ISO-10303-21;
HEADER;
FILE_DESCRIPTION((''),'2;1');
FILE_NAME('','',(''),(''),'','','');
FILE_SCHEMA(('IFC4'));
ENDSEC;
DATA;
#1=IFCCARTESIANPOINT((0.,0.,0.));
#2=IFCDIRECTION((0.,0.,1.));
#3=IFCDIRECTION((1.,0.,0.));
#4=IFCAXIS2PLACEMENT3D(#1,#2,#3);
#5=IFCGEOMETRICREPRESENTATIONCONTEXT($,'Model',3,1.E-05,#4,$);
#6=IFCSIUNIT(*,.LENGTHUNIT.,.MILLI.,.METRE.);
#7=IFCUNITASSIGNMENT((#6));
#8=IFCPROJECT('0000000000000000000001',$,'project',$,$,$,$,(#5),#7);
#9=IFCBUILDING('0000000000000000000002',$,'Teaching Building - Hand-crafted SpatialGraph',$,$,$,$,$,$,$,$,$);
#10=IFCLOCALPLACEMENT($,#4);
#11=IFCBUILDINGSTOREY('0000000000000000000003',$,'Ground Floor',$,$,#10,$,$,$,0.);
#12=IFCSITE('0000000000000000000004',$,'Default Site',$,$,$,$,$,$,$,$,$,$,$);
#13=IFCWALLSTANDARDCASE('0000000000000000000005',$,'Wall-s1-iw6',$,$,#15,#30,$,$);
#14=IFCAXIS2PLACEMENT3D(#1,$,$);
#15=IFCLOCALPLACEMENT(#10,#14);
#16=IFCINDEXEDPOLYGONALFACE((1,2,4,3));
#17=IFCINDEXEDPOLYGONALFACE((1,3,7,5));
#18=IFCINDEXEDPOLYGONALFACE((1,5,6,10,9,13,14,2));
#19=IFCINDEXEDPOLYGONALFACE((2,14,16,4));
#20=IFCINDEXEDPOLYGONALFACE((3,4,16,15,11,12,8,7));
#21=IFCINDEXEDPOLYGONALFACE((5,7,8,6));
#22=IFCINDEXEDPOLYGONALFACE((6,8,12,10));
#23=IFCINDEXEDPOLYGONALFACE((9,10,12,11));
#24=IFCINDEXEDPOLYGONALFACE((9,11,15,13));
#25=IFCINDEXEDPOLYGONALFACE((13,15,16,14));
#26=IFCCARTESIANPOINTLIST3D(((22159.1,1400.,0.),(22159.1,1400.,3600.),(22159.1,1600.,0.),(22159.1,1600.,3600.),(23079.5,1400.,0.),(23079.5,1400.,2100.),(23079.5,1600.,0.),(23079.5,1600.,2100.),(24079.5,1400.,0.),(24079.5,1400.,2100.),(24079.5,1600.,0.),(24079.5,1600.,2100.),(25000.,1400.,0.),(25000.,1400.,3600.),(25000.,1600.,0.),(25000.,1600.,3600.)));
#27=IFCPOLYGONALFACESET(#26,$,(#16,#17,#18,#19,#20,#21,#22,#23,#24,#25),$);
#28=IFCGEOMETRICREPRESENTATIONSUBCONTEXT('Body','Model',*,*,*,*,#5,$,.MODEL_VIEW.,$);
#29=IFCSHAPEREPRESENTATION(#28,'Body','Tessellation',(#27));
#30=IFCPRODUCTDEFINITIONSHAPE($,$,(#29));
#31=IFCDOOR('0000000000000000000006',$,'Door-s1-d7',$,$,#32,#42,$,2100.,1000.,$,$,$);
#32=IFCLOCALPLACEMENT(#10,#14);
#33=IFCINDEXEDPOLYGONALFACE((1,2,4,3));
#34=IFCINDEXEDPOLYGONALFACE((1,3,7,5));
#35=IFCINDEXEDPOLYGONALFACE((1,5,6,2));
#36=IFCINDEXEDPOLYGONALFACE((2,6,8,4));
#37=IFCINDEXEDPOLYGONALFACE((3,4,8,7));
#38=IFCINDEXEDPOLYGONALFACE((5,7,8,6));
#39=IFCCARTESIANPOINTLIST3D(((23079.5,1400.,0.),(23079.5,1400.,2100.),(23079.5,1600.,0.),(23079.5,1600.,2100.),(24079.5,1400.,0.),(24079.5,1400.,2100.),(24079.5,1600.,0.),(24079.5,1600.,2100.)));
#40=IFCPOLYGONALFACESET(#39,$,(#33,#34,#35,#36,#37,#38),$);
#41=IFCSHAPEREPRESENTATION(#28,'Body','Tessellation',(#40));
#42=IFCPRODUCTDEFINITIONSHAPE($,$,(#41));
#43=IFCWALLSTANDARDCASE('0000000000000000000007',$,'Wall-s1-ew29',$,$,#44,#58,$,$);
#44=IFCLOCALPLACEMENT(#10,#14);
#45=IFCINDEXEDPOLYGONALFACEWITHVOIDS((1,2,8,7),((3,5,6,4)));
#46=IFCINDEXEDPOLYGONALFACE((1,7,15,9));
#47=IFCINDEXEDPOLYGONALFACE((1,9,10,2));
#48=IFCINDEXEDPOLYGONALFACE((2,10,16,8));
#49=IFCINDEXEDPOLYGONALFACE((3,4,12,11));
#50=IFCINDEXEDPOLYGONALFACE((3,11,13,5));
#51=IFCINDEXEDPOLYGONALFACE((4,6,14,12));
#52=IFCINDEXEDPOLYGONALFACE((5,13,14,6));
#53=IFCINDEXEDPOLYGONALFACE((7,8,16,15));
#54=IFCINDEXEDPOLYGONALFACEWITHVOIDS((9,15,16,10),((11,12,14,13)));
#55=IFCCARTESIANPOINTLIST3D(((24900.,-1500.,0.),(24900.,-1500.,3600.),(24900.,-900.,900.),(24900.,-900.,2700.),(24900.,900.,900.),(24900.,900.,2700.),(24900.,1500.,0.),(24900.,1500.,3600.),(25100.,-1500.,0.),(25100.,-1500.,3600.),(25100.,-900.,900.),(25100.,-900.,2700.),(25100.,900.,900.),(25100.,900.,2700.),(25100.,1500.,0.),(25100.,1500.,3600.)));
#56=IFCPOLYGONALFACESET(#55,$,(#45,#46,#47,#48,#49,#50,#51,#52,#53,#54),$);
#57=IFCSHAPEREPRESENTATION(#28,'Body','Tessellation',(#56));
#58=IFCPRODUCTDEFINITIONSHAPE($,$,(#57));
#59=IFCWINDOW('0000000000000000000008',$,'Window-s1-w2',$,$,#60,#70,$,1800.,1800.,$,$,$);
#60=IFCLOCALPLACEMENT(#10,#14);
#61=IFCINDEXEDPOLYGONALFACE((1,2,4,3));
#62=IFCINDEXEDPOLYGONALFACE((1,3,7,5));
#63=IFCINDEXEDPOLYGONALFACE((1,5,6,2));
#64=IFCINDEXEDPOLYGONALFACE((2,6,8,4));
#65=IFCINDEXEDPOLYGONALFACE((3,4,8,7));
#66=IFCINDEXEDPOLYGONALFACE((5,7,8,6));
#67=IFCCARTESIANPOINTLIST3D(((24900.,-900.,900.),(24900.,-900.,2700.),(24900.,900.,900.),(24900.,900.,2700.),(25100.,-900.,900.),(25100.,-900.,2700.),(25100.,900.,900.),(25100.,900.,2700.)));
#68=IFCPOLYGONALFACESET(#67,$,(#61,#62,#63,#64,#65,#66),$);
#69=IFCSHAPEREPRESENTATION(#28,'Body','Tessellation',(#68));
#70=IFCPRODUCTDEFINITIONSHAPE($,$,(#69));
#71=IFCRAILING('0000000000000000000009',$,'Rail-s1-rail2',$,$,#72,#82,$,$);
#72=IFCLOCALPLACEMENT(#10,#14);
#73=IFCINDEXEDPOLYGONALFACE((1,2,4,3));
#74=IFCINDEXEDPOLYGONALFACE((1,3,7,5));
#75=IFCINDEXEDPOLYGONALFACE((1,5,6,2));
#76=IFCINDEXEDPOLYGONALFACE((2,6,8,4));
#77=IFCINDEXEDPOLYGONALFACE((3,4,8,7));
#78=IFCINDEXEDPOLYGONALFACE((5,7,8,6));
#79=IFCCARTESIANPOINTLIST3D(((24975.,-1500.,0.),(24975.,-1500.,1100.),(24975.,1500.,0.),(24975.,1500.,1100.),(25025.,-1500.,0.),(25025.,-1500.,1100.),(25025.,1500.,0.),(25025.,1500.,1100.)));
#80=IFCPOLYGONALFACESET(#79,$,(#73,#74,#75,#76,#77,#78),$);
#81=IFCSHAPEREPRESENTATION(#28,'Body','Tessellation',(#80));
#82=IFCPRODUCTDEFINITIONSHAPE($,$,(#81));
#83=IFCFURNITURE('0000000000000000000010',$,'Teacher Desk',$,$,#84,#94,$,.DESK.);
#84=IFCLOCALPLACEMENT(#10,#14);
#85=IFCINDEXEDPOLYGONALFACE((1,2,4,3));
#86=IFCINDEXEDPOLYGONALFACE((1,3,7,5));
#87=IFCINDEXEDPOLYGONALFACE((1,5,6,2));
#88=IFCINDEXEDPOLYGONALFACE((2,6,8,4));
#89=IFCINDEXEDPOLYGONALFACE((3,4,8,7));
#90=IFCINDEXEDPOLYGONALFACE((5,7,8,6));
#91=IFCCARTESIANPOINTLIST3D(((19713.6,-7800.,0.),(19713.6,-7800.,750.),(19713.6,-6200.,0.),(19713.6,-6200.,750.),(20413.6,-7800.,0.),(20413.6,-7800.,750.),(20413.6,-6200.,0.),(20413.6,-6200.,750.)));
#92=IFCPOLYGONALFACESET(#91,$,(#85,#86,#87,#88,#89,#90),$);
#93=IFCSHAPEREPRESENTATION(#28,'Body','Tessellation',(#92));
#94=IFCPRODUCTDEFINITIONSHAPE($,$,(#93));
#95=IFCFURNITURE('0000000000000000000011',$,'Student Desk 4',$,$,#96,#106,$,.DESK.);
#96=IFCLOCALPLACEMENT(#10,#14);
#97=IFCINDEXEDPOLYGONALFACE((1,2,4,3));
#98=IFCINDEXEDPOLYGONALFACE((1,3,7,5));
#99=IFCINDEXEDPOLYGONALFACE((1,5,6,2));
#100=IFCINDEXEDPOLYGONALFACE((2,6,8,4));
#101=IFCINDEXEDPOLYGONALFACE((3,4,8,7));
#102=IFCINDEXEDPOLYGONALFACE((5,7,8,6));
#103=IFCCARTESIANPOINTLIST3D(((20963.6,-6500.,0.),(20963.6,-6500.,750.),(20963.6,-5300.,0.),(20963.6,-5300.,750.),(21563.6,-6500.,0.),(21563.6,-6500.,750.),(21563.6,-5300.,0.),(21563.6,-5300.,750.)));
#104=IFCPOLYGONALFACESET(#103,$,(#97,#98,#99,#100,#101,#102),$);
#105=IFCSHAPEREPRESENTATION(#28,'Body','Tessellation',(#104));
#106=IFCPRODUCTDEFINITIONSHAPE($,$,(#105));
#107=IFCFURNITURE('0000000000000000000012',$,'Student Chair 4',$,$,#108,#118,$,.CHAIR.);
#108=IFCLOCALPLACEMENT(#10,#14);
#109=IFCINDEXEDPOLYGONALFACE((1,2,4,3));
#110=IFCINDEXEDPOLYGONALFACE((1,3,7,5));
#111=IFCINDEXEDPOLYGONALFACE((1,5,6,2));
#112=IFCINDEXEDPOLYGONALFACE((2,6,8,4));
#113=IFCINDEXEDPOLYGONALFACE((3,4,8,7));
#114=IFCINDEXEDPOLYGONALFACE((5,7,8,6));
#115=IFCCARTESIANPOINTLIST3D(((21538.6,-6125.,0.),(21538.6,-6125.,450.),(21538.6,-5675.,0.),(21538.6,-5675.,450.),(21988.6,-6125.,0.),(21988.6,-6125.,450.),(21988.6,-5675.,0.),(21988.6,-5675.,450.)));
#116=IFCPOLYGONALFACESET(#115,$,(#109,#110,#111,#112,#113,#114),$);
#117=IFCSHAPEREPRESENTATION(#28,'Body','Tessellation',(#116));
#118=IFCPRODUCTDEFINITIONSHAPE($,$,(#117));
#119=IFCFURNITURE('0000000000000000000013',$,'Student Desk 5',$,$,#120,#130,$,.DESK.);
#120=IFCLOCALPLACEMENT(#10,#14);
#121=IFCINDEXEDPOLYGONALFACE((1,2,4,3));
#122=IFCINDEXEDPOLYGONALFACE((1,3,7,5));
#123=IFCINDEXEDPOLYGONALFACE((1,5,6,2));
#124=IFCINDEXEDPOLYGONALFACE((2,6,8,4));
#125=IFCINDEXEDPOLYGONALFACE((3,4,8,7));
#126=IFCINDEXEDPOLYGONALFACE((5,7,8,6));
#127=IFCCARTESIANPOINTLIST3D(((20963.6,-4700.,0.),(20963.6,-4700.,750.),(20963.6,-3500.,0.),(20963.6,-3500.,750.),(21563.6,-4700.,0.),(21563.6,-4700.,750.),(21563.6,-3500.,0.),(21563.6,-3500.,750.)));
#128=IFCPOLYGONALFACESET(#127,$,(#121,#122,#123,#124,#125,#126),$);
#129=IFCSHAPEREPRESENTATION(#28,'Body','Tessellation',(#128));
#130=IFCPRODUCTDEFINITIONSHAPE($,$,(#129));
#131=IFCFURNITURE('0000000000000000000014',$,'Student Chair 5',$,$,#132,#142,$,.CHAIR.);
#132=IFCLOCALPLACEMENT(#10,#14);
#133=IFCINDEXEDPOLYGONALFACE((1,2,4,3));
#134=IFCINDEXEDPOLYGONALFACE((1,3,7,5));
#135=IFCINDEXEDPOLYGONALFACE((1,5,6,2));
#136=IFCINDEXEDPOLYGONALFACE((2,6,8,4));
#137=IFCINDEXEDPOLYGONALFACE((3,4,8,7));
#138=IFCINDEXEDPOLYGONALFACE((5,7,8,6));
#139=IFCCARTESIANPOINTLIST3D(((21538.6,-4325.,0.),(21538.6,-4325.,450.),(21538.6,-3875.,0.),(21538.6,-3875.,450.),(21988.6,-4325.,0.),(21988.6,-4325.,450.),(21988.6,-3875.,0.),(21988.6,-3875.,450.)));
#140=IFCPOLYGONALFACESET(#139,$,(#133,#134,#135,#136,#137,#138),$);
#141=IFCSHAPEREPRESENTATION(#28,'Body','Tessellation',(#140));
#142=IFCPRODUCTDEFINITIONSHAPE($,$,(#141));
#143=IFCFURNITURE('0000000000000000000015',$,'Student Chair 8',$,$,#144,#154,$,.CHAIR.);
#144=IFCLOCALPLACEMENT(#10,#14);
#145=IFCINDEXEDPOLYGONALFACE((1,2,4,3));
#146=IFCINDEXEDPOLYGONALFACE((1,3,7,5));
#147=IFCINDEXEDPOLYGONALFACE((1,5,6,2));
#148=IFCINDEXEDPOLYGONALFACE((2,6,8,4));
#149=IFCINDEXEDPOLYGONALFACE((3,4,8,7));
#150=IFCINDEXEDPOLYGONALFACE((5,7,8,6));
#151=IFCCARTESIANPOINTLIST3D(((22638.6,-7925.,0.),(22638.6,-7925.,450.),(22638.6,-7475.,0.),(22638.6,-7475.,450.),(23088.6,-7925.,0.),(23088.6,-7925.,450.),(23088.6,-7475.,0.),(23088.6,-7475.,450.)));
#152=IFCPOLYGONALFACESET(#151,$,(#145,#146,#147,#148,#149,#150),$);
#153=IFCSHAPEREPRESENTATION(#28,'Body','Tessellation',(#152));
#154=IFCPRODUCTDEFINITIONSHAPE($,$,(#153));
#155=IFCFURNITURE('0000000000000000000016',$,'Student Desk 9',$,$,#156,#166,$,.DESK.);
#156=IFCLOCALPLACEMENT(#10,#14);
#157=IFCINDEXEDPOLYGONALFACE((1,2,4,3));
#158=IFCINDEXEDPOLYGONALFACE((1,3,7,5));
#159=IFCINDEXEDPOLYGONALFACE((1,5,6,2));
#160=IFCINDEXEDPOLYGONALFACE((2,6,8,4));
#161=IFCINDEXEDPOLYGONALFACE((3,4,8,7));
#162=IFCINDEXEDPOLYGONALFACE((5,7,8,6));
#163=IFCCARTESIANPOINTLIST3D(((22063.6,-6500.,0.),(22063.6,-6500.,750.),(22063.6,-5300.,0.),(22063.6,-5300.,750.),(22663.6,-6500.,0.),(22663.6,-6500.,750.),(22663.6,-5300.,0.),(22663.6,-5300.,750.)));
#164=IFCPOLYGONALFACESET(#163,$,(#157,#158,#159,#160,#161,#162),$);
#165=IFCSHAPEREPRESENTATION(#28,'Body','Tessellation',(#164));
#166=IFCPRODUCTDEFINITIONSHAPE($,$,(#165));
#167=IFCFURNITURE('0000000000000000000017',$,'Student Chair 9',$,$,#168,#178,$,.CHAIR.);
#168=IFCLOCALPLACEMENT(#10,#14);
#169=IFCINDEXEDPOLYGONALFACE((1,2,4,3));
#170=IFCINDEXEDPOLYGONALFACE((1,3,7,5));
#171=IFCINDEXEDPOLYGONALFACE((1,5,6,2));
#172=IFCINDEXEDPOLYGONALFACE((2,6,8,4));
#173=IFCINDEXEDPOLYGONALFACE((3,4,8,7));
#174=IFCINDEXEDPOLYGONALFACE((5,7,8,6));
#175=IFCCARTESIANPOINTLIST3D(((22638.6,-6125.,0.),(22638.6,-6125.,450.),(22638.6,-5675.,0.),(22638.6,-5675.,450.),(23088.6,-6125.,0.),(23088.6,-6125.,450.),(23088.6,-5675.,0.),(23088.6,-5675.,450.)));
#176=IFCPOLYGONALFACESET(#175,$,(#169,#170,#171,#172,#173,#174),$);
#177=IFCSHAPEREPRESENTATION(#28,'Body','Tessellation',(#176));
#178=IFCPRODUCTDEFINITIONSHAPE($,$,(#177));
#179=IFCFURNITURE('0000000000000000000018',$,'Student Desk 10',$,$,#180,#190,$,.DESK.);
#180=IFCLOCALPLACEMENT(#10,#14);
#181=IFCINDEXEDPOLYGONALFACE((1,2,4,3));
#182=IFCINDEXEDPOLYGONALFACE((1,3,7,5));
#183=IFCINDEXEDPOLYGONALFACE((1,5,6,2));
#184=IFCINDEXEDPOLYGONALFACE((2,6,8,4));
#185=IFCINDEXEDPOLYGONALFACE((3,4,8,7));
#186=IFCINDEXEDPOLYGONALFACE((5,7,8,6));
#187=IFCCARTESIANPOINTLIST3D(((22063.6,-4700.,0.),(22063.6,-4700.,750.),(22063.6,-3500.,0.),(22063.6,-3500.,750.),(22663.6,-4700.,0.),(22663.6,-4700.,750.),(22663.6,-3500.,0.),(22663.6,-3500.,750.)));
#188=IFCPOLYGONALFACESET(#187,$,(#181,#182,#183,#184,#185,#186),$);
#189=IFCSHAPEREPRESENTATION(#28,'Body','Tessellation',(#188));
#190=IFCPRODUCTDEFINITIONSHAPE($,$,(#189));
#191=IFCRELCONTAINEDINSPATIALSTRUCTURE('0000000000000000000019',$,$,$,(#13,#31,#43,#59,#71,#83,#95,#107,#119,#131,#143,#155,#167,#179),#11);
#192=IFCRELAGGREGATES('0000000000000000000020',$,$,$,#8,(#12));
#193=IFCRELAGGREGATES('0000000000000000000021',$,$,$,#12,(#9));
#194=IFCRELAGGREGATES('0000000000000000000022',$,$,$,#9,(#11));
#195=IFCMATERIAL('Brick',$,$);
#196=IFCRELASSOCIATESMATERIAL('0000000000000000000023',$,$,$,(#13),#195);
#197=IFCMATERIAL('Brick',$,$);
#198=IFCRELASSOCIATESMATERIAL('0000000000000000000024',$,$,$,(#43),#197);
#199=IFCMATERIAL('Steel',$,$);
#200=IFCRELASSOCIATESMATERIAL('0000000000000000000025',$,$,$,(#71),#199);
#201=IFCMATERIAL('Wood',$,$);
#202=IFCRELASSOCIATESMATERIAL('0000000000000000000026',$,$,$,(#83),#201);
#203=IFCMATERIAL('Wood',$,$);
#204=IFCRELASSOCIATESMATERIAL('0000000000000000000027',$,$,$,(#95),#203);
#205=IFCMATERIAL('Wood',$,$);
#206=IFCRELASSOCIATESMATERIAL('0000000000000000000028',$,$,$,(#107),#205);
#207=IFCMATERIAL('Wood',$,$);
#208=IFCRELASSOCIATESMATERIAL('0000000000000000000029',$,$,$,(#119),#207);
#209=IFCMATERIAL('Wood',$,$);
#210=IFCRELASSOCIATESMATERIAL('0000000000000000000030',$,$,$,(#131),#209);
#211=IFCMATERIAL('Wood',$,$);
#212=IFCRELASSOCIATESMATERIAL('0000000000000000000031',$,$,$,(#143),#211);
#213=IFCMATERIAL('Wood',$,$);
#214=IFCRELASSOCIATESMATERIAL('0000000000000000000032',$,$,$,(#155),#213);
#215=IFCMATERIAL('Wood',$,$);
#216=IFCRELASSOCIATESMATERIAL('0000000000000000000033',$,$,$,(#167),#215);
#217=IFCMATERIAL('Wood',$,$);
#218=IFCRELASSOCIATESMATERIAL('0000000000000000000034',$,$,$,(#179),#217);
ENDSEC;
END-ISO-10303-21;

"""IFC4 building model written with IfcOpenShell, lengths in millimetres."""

from ifc_helpers import new_model, si_unit, frame, frame_2d, origin_with_axes, origin_2d, place, context, subcontext, project, spatial, rectangle, extrude, material, element, fill, save


model = new_model("IFC4")

# Units and contexts
model_context = context("Model", 3, precision=1e-05, world=origin_with_axes())
body_context = subcontext(model_context, "Body", "Model", "MODEL_VIEW")
ifc_project = project(units=[si_unit("LENGTHUNIT", "METRE", prefix="MILLI")], contexts=[model_context])

# Site, building, storey
site = spatial("IfcSite", under=ifc_project, Name="Default Site")
building = spatial("IfcBuilding", under=site, Name="Teaching Building - Hand-crafted SpatialGraph")
storey_placement = place(None, origin_with_axes())
storey = spatial("IfcBuildingStorey", under=building, at=storey_placement, Name="Ground Floor", Elevation=0.0)

# Wall, opening, door
ifc_material_1 = material(Name="Brick")
wall_1_placement = place(storey_placement, frame((22159.1, 1500.0, 0.0), z_axis=(0.0, 0.0, 1.0), x_axis=(1.0, 0.0, 0.0)))
wall_1 = element("IfcWallStandardCase", 1, at=wall_1_placement, inside=storey, material=ifc_material_1, Name="Wall-s1-iw6", context=body_context, shape_type="SweptSolid", body=[
    extrude(rectangle(XDim=2840.9, YDim=200.0, at=frame_2d((1420.5, 0.0))), origin_with_axes(), (0.0, 0.0, 1.0), 3600.0),
])
opening_1_placement = place(wall_1_placement, frame((920.5, 0.0, 0.0), z_axis=(0.0, 0.0, 1.0), x_axis=(1.0, 0.0, 0.0)))
opening_1 = element("IfcOpeningElement", 2, at=opening_1_placement, cuts=wall_1, context=body_context, shape_type="SweptSolid", body=[
    extrude(rectangle(XDim=1000.0, YDim=400.0, at=frame_2d((500.0, 0.0))), origin_with_axes(), (0.0, 0.0, 1.0), 2100.0),
])
door_placement = place(storey_placement, frame((23079.5, 1500.0, 0.0), z_axis=(0.0, 0.0, 1.0), x_axis=(1.0, 0.0, 0.0)))
door = element("IfcDoor", 3, at=door_placement, inside=storey, Name="Door-s1-d7", OverallHeight=2100.0, OverallWidth=1000.0, context=body_context, shape_type="SweptSolid", body=[
    extrude(rectangle(XDim=1000.0, YDim=200.0, at=frame_2d((500.0, 0.0))), origin_with_axes(), (0.0, 0.0, 1.0), 2100.0),
])
fill(opening_1, door)

# Wall, opening, window
ifc_material_2 = material(Name="Brick")
wall_2_placement = place(storey_placement, frame((25000.0, -1500.0, 0.0), z_axis=(0.0, 0.0, 1.0), x_axis=(0.0, 1.0, 0.0)))
wall_2 = element("IfcWallStandardCase", 4, at=wall_2_placement, inside=storey, material=ifc_material_2, Name="Wall-s1-ew29", context=body_context, shape_type="SweptSolid", body=[
    extrude(rectangle(XDim=3000.0, YDim=200.0, at=frame_2d((1500.0, 0.0))), origin_with_axes(), (0.0, 0.0, 1.0), 3600.0),
])
opening_2_placement = place(wall_2_placement, frame((600.0, 0.0, 900.0), z_axis=(0.0, 0.0, 1.0), x_axis=(1.0, 0.0, 0.0)))
opening_2 = element("IfcOpeningElement", 5, at=opening_2_placement, cuts=wall_2, context=body_context, shape_type="SweptSolid", body=[
    extrude(rectangle(XDim=1800.0, YDim=400.0, at=frame_2d((900.0, 0.0))), origin_with_axes(), (0.0, 0.0, 1.0), 1800.0),
])
window_placement = place(storey_placement, frame((25000.0, -900.0, 900.0), z_axis=(0.0, 0.0, 1.0), x_axis=(0.0, 1.0, 0.0)))
window = element("IfcWindow", 6, at=window_placement, inside=storey, Name="Window-s1-w2", OverallHeight=1800.0, OverallWidth=1800.0, context=body_context, shape_type="SweptSolid", body=[
    extrude(rectangle(XDim=1800.0, YDim=200.0, at=frame_2d((900.0, 0.0))), origin_with_axes(), (0.0, 0.0, 1.0), 1800.0),
])
fill(opening_2, window)

# Railing
ifc_material_3 = material(Name="Steel")
railing_placement = place(storey_placement, frame((25000.0, -1500.0, 0.0), z_axis=(0.0, 0.0, 1.0), x_axis=(0.0, 1.0, 0.0)))
element("IfcRailing", 7, at=railing_placement, inside=storey, material=ifc_material_3, Name="Rail-s1-rail2", context=body_context, shape_type="SweptSolid", body=[
    extrude(rectangle(XDim=3000.0, YDim=50.0, at=frame_2d((1500.0, 0.0))), origin_with_axes(), (0.0, 0.0, 1.0), 1100.0),
])

# Furniture
ifc_material_4 = material(Name="Wood")
furniture_1_placement = place(storey_placement, frame((20063.6, -7000.0, 0.0), z_axis=(0.0, 0.0, 1.0), x_axis=(0.0, 1.0, 0.0)))
element("IfcFurniture", 8, at=furniture_1_placement, inside=storey, material=ifc_material_4, Name="Teacher Desk", PredefinedType="DESK", context=body_context, shape_type="SweptSolid", body=[
    extrude(rectangle(XDim=1600.0, YDim=700.0, at=origin_2d()), origin_with_axes(), (0.0, 0.0, 1.0), 750.0),
])
ifc_material_5 = material(Name="Wood")
furniture_2_placement = place(storey_placement, frame((21263.6, -5900.0, 0.0), z_axis=(0.0, 0.0, 1.0), x_axis=(0.0, 1.0, 0.0)))
element("IfcFurniture", 9, at=furniture_2_placement, inside=storey, material=ifc_material_5, Name="Student Desk 4", PredefinedType="DESK", context=body_context, shape_type="SweptSolid", body=[
    extrude(rectangle(XDim=1200.0, YDim=600.0, at=origin_2d()), origin_with_axes(), (0.0, 0.0, 1.0), 750.0),
])
ifc_material_6 = material(Name="Wood")
furniture_3_placement = place(storey_placement, frame((21763.6, -5900.0, 0.0), z_axis=(0.0, 0.0, 1.0), x_axis=(1.0, 0.0, 0.0)))
element("IfcFurniture", 10, at=furniture_3_placement, inside=storey, material=ifc_material_6, Name="Student Chair 4", PredefinedType="CHAIR", context=body_context, shape_type="SweptSolid", body=[
    extrude(rectangle(XDim=450.0, YDim=450.0, at=origin_2d()), origin_with_axes(), (0.0, 0.0, 1.0), 450.0),
])
ifc_material_7 = material(Name="Wood")
furniture_4_placement = place(storey_placement, frame((21263.6, -4100.0, 0.0), z_axis=(0.0, 0.0, 1.0), x_axis=(0.0, 1.0, 0.0)))
element("IfcFurniture", 11, at=furniture_4_placement, inside=storey, material=ifc_material_7, Name="Student Desk 5", PredefinedType="DESK", context=body_context, shape_type="SweptSolid", body=[
    extrude(rectangle(XDim=1200.0, YDim=600.0, at=origin_2d()), origin_with_axes(), (0.0, 0.0, 1.0), 750.0),
])
ifc_material_8 = material(Name="Wood")
furniture_5_placement = place(storey_placement, frame((21763.6, -4100.0, 0.0), z_axis=(0.0, 0.0, 1.0), x_axis=(1.0, 0.0, 0.0)))
element("IfcFurniture", 12, at=furniture_5_placement, inside=storey, material=ifc_material_8, Name="Student Chair 5", PredefinedType="CHAIR", context=body_context, shape_type="SweptSolid", body=[
    extrude(rectangle(XDim=450.0, YDim=450.0, at=origin_2d()), origin_with_axes(), (0.0, 0.0, 1.0), 450.0),
])
ifc_material_9 = material(Name="Wood")
furniture_6_placement = place(storey_placement, frame((22863.6, -7700.0, 0.0), z_axis=(0.0, 0.0, 1.0), x_axis=(1.0, 0.0, 0.0)))
element("IfcFurniture", 13, at=furniture_6_placement, inside=storey, material=ifc_material_9, Name="Student Chair 8", PredefinedType="CHAIR", context=body_context, shape_type="SweptSolid", body=[
    extrude(rectangle(XDim=450.0, YDim=450.0, at=origin_2d()), origin_with_axes(), (0.0, 0.0, 1.0), 450.0),
])
ifc_material_10 = material(Name="Wood")
furniture_7_placement = place(storey_placement, frame((22363.6, -5900.0, 0.0), z_axis=(0.0, 0.0, 1.0), x_axis=(0.0, 1.0, 0.0)))
element("IfcFurniture", 14, at=furniture_7_placement, inside=storey, material=ifc_material_10, Name="Student Desk 9", PredefinedType="DESK", context=body_context, shape_type="SweptSolid", body=[
    extrude(rectangle(XDim=1200.0, YDim=600.0, at=origin_2d()), origin_with_axes(), (0.0, 0.0, 1.0), 750.0),
])
ifc_material_11 = material(Name="Wood")
furniture_8_placement = place(storey_placement, frame((22863.6, -5900.0, 0.0), z_axis=(0.0, 0.0, 1.0), x_axis=(1.0, 0.0, 0.0)))
element("IfcFurniture", 15, at=furniture_8_placement, inside=storey, material=ifc_material_11, Name="Student Chair 9", PredefinedType="CHAIR", context=body_context, shape_type="SweptSolid", body=[
    extrude(rectangle(XDim=450.0, YDim=450.0, at=origin_2d()), origin_with_axes(), (0.0, 0.0, 1.0), 450.0),
])
ifc_material_12 = material(Name="Wood")
furniture_9_placement = place(storey_placement, frame((22363.6, -4100.0, 0.0), z_axis=(0.0, 0.0, 1.0), x_axis=(0.0, 1.0, 0.0)))
element("IfcFurniture", 16, at=furniture_9_placement, inside=storey, material=ifc_material_12, Name="Student Desk 10", PredefinedType="DESK", context=body_context, shape_type="SweptSolid", body=[
    extrude(rectangle(XDim=1200.0, YDim=600.0, at=origin_2d()), origin_with_axes(), (0.0, 0.0, 1.0), 750.0),
])

save(model, "model.ifc")
